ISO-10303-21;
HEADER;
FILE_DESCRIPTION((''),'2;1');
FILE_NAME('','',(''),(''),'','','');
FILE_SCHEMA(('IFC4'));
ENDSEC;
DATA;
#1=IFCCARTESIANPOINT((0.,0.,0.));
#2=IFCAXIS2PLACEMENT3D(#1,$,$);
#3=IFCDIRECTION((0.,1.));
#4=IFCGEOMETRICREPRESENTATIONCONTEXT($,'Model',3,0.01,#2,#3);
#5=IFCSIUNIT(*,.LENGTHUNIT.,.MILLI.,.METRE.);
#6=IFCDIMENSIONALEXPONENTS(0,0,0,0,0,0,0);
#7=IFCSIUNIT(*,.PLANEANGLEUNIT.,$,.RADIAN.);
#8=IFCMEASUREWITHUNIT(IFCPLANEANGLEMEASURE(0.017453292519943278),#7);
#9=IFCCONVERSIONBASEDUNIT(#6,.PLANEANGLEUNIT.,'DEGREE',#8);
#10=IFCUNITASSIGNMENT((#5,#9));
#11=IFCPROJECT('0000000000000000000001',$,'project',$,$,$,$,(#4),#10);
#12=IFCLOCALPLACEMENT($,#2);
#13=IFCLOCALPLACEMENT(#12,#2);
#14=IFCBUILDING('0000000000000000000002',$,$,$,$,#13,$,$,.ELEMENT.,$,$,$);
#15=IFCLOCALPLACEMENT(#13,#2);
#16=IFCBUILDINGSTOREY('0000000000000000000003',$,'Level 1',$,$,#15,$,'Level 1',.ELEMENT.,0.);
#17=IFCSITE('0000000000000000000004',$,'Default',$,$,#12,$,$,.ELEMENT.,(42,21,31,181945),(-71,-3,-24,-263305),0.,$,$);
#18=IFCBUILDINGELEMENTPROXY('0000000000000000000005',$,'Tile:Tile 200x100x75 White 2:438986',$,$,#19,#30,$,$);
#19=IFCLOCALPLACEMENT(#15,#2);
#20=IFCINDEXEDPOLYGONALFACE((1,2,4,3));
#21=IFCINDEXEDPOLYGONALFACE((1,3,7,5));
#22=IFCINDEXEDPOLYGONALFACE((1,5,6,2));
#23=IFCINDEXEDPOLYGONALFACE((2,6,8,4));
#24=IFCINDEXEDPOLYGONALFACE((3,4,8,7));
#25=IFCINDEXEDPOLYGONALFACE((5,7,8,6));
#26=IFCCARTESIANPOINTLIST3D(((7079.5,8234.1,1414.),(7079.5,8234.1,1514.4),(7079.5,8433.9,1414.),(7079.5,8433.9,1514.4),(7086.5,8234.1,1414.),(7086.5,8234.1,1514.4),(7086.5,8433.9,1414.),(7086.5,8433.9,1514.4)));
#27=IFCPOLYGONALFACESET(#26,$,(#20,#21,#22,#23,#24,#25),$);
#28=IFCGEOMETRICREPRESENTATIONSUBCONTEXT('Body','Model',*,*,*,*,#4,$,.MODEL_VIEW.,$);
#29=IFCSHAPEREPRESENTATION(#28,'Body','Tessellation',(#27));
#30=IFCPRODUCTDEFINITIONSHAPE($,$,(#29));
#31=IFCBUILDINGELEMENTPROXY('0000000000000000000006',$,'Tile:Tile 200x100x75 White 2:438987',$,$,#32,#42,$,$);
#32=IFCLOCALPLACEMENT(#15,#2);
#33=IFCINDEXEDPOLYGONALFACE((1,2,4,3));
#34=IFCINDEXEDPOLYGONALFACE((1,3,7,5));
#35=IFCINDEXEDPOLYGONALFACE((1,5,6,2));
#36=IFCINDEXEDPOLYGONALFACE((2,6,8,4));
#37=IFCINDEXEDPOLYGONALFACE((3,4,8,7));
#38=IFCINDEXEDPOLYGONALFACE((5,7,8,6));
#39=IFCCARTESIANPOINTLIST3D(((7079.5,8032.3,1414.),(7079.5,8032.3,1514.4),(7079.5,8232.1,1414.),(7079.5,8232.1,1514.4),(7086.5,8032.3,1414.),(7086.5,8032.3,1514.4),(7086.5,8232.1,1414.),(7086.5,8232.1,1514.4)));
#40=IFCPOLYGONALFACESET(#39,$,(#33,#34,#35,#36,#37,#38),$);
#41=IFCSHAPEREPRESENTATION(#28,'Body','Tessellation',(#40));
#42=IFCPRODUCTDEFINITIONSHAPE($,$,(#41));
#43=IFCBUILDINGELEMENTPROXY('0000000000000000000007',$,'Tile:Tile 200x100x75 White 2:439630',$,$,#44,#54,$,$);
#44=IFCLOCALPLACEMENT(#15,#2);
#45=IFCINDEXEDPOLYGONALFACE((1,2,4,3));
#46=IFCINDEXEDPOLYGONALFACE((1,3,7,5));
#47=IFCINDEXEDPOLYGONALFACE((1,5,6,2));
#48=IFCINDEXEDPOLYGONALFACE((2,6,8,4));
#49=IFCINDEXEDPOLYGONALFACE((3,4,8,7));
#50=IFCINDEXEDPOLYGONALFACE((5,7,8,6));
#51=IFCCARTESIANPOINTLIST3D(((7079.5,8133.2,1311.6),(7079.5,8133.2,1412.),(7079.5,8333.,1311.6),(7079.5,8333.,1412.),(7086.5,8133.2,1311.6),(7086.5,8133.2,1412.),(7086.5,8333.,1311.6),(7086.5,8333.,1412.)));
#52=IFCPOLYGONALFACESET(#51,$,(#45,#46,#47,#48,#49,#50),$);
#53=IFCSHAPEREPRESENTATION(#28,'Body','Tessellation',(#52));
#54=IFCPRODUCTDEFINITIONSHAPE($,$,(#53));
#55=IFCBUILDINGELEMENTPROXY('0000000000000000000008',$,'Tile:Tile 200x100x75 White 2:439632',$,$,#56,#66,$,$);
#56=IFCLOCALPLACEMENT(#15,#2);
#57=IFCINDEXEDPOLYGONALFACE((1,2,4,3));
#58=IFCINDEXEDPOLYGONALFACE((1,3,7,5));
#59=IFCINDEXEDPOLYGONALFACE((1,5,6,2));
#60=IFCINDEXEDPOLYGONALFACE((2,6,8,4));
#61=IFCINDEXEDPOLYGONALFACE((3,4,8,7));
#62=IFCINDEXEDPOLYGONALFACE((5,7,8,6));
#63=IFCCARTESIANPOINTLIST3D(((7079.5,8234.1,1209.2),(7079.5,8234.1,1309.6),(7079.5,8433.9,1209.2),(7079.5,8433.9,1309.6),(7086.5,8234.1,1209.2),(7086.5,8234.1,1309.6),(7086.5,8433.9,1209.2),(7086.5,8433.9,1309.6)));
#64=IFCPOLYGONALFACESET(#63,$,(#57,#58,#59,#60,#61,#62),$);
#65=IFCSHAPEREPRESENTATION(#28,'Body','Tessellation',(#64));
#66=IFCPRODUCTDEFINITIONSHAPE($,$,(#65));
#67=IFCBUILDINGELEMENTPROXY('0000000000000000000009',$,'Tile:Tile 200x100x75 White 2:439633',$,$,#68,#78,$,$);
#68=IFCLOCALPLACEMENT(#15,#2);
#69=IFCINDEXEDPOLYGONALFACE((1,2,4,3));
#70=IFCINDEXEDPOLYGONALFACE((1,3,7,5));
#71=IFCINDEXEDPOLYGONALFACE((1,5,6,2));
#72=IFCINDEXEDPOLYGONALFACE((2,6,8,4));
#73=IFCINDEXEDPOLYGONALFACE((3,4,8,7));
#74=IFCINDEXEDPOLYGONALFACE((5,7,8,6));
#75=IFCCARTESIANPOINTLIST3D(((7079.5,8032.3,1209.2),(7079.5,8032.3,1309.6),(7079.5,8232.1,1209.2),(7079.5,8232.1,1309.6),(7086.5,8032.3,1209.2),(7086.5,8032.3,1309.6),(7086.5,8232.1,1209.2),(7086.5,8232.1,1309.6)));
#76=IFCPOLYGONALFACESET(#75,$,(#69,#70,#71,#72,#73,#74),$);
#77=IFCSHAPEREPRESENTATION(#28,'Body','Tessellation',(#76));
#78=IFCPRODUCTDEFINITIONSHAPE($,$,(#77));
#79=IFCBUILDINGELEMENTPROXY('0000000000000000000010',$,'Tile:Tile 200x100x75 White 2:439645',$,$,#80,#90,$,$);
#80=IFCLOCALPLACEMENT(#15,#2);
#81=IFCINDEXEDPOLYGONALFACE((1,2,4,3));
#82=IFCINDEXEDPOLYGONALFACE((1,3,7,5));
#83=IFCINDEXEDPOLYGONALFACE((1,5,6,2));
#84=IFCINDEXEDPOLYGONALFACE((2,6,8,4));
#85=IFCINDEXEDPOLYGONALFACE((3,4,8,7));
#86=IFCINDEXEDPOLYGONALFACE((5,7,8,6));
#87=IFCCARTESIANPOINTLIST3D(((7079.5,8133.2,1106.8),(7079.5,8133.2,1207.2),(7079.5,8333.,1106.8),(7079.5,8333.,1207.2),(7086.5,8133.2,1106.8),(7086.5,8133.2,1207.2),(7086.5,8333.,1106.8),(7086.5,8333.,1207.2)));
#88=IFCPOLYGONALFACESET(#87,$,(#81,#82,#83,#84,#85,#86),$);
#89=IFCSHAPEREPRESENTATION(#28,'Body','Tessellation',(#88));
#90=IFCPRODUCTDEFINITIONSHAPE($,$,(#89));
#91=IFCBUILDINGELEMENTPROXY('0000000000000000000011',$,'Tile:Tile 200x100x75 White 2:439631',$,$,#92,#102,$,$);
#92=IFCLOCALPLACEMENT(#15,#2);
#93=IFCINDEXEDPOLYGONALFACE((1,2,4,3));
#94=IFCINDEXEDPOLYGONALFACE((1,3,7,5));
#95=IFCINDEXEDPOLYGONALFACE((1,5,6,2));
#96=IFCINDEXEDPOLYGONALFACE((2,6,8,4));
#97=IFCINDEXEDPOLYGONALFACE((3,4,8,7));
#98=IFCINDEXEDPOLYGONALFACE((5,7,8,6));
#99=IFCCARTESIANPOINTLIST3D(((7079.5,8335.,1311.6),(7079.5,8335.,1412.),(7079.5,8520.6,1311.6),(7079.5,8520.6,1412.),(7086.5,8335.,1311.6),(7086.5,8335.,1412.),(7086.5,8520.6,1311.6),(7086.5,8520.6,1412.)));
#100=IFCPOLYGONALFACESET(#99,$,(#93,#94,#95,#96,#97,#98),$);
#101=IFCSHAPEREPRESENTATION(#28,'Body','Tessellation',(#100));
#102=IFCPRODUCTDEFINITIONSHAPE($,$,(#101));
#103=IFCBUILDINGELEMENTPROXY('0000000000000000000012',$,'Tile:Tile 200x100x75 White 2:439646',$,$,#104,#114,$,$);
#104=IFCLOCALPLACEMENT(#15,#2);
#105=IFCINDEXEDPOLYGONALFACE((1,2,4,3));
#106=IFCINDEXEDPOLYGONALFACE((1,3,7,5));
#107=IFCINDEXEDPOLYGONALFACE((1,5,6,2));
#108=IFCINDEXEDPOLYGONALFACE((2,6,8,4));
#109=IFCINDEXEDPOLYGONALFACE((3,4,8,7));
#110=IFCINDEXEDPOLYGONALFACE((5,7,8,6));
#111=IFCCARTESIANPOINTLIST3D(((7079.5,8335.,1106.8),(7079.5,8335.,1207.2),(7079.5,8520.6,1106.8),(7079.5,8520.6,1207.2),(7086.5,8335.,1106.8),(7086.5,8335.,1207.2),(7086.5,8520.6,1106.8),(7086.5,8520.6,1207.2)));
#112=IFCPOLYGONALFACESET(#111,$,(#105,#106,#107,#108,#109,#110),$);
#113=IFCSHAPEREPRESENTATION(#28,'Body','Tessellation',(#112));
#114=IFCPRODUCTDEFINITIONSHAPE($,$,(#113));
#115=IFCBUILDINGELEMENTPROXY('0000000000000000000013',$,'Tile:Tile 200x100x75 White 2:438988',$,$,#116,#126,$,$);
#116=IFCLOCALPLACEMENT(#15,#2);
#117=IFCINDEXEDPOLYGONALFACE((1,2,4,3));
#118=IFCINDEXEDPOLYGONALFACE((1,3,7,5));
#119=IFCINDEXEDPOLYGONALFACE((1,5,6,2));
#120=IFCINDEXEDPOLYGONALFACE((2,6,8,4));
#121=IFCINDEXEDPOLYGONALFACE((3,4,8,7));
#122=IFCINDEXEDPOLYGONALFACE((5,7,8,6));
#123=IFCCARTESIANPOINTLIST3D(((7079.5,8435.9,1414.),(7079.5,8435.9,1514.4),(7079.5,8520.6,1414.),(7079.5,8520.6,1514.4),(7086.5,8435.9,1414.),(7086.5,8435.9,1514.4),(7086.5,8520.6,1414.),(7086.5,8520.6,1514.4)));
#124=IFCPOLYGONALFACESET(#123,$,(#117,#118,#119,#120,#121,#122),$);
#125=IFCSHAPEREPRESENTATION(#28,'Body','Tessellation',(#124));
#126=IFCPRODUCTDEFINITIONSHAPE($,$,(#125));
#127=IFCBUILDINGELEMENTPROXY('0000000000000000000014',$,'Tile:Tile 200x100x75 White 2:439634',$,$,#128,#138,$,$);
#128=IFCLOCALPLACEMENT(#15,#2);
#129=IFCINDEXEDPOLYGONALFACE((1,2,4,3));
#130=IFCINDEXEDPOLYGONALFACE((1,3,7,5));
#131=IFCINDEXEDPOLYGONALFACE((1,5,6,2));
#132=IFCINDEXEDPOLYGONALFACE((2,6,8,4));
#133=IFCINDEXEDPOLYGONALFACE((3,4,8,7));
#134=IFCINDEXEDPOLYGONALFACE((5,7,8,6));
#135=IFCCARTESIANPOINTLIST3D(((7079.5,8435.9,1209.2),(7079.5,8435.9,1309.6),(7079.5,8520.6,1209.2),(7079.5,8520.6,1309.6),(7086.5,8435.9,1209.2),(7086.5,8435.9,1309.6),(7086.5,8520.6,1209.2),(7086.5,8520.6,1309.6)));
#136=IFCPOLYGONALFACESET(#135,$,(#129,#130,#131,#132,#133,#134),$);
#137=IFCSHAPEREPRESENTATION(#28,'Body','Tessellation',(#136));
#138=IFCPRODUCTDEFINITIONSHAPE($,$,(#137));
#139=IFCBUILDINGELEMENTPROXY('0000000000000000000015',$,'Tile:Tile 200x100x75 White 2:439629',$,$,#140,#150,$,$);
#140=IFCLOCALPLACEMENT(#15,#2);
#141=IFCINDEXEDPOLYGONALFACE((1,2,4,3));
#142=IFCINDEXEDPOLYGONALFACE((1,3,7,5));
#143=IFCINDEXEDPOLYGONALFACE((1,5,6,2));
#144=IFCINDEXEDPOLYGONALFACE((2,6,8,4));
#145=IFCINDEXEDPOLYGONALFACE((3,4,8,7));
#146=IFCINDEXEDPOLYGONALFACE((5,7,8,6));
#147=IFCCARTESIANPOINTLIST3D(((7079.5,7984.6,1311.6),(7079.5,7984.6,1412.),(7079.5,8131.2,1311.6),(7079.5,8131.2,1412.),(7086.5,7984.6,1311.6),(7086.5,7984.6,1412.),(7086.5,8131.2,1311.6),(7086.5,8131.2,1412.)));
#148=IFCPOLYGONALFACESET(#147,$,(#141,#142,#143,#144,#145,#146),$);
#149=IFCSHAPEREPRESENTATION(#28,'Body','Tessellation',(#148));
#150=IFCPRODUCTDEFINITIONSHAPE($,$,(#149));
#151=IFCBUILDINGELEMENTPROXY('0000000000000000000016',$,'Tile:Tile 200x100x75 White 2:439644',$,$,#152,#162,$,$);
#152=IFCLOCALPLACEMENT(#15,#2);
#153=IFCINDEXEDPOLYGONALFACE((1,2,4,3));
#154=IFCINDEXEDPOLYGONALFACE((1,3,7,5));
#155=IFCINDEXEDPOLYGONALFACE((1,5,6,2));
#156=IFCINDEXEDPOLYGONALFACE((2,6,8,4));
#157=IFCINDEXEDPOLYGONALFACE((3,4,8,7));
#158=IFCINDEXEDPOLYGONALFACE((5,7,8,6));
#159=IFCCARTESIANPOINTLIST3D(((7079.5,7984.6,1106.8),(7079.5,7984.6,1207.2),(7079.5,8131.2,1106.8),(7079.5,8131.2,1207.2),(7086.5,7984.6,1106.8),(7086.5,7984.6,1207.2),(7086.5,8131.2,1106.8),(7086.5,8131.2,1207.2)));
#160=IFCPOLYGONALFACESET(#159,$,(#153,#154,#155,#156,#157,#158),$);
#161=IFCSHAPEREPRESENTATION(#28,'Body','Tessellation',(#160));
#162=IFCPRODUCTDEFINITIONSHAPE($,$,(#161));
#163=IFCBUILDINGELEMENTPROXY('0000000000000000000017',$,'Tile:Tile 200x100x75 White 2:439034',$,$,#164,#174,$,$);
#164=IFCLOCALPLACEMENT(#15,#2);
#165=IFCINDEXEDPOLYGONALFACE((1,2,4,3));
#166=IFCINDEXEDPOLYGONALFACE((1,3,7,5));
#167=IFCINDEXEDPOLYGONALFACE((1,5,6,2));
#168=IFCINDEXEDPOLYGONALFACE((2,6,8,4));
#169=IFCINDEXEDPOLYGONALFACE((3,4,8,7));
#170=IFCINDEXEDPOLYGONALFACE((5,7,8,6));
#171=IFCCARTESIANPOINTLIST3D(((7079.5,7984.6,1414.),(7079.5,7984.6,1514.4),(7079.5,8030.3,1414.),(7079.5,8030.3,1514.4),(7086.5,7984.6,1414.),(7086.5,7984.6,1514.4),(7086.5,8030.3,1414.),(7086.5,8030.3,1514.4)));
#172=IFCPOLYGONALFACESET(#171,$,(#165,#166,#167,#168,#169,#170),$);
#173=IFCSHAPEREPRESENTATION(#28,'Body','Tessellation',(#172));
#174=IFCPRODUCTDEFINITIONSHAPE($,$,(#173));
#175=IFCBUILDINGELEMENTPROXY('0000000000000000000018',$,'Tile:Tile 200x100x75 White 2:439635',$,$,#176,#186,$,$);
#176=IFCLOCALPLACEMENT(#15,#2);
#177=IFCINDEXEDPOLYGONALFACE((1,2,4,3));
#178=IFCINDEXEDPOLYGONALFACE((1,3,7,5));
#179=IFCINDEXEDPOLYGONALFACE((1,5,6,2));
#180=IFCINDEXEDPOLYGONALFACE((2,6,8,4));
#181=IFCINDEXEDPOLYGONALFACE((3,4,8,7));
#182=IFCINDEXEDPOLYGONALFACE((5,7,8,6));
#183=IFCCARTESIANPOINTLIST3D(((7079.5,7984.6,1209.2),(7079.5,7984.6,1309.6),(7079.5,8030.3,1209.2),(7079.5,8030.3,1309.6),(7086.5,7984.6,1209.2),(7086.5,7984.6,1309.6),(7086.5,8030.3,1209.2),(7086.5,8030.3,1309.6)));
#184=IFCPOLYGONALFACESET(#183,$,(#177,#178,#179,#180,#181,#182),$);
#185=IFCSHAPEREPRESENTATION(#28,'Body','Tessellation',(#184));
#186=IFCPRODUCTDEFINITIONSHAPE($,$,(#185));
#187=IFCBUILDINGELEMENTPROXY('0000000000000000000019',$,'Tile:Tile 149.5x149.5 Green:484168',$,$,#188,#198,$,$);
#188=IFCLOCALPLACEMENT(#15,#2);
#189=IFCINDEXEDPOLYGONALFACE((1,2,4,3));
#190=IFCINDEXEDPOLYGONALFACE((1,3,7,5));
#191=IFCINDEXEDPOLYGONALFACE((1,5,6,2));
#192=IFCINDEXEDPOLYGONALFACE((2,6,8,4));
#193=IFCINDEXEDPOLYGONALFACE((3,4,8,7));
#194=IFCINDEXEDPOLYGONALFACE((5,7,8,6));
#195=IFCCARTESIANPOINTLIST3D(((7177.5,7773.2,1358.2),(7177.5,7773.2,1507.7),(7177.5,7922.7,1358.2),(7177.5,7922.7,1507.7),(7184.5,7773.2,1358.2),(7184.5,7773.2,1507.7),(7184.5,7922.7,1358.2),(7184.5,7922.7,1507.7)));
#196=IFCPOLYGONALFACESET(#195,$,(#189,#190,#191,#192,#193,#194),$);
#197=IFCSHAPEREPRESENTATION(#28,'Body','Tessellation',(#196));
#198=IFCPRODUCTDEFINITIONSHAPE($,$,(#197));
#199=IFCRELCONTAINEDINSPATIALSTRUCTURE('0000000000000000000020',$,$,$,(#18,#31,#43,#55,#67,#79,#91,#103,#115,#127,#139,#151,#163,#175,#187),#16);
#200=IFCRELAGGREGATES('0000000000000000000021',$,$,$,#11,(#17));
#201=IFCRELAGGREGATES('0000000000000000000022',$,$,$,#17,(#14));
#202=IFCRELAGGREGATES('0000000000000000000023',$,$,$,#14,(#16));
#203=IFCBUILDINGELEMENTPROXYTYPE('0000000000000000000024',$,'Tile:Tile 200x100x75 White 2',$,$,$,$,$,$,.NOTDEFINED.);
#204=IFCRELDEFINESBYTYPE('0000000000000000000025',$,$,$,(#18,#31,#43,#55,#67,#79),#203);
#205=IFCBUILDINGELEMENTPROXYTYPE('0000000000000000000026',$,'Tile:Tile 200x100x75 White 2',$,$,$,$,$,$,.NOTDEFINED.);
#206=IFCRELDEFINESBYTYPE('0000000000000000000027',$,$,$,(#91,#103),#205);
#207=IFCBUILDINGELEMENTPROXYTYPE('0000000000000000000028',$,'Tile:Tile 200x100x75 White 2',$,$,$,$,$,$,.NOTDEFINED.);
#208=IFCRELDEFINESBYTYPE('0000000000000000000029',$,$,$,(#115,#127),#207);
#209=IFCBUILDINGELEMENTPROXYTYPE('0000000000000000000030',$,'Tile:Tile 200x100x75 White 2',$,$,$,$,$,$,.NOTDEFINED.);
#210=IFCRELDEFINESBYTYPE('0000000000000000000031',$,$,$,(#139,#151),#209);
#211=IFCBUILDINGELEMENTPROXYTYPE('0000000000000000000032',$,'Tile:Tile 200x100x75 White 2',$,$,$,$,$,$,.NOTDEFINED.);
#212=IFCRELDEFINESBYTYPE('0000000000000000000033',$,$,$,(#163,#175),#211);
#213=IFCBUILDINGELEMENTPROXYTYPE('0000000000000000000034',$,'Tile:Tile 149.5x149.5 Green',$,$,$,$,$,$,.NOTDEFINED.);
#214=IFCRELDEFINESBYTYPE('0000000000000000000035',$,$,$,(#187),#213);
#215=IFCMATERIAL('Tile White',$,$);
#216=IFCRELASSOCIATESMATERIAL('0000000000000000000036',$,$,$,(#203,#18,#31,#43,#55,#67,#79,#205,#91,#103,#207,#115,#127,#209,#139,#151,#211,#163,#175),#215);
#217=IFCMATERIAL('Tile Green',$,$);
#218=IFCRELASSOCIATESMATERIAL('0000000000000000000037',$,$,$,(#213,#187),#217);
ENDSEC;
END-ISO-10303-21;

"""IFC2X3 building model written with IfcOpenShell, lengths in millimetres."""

from ifc_helpers import new_model, entity, si_unit, converted_unit, direction, frame, frame_2d, origin, origin_2d_with_axis, place, context, subcontext, project, spatial, rectangle, extrude, source, transform, mapped, material, type_object, type_shapes, element, save


model = new_model("IFC2X3")

# Units and contexts
model_context = context("Model", 3, precision=0.01, world=origin(), true_north=direction((0.0, 1.0)))
body_context = subcontext(model_context, "Body", "Model", "MODEL_VIEW")
ifc_project = project(units=[si_unit("LENGTHUNIT", "METRE", prefix="MILLI"), converted_unit("PLANEANGLEUNIT", "DEGREE", entity("IfcPlaneAngleMeasure", 0.017453292519943278), si_unit("PLANEANGLEUNIT", "RADIAN"), dimensions=[0, 0, 0, 0, 0, 0, 0])], contexts=[model_context])

# Site, building, storey
site_placement = place(None, origin())
site = spatial("IfcSite", under=ifc_project, at=site_placement, Name="Default", CompositionType="ELEMENT", RefLatitude=(42, 21, 31, 181945), RefLongitude=(-71, -3, -24, -263305), RefElevation=0.0)
building_placement = place(site_placement, origin())
building = spatial("IfcBuilding", under=site, at=building_placement, CompositionType="ELEMENT")
storey_placement = place(building_placement, origin())
storey = spatial("IfcBuildingStorey", under=building, at=storey_placement, Name="Level 1", LongName="Level 1", CompositionType="ELEMENT", Elevation=0.0)

# Building element proxies
ifc_material_1 = material(Name="Tile White")
building_element_proxy_type_1 = type_object("IfcBuildingElementProxyType", Name="Tile:Tile 200x100x75 White 2", PredefinedType="NOTDEFINED", material=ifc_material_1)
shared_shape_1 = source(origin(), body_context, "Body", "SweptSolid", [
    extrude(rectangle(XDim=199.8, YDim=100.4, at=frame_2d((0.0, 0.0), x_axis=(1.0, 0.0))), frame((-50.2, -99.9, 0.0), z_axis=(0.0, 0.0, 1.0), x_axis=(0.0, -1.0, 0.0)), (0.0, 0.0, 1.0), 7.0),
])
type_shapes(building_element_proxy_type_1, [shared_shape_1])
for number, where, z_axis, x_axis, name in (
    (1, (7086.5, 8433.9, 1514.4), (-1.0, 0.0, 0.0), (0.0, 0.0, 1.0), "Tile:Tile 200x100x75 White 2:438986"),
    (2, (7086.5, 8232.1, 1514.4), (-1.0, 0.0, 0.0), (0.0, 0.0, 1.0), "Tile:Tile 200x100x75 White 2:438987"),
    (3, (7086.5, 8333.0, 1412.0), (-1.0, 0.0, 0.0), (0.0, 0.0, 1.0), "Tile:Tile 200x100x75 White 2:439630"),
    (4, (7086.5, 8433.9, 1309.6), (-1.0, 0.0, 0.0), (0.0, 0.0, 1.0), "Tile:Tile 200x100x75 White 2:439632"),
    (5, (7086.5, 8232.1, 1309.6), (-1.0, 0.0, 0.0), (0.0, 0.0, 1.0), "Tile:Tile 200x100x75 White 2:439633"),
    (6, (7086.5, 8333.0, 1207.2), (-1.0, 0.0, 0.0), (0.0, 0.0, 1.0), "Tile:Tile 200x100x75 White 2:439645"),
):
    element("IfcBuildingElementProxy", number, at=place(storey_placement, frame(where, z_axis=z_axis, x_axis=x_axis)), inside=storey, type_object=building_element_proxy_type_1, material=ifc_material_1, Name=name, context=body_context, shape_type="MappedRepresentation", body=[
        mapped(shared_shape_1, transform((0.0, 0.0, 0.0), scale=1.0)),
    ])
building_element_proxy_type_2 = type_object("IfcBuildingElementProxyType", Name="Tile:Tile 200x100x75 White 2", PredefinedType="NOTDEFINED", material=ifc_material_1)
shared_shape_2 = source(origin(), body_context, "Body", "SweptSolid", [
    extrude(rectangle(XDim=185.6, YDim=100.4, at=frame_2d((0.0, 0.0), x_axis=(1.0, 0.0))), frame((-50.2, -92.8, 0.0), z_axis=(0.0, 0.0, 1.0), x_axis=(0.0, -1.0, 0.0)), (0.0, 0.0, 1.0), 7.0),
])
type_shapes(building_element_proxy_type_2, [shared_shape_2])
for number, where, z_axis, x_axis, name in (
    (7, (7086.5, 8520.6, 1412.0), (-1.0, 0.0, 0.0), (0.0, 0.0, 1.0), "Tile:Tile 200x100x75 White 2:439631"),
    (8, (7086.5, 8520.6, 1207.2), (-1.0, 0.0, 0.0), (0.0, 0.0, 1.0), "Tile:Tile 200x100x75 White 2:439646"),
):
    element("IfcBuildingElementProxy", number, at=place(storey_placement, frame(where, z_axis=z_axis, x_axis=x_axis)), inside=storey, type_object=building_element_proxy_type_2, material=ifc_material_1, Name=name, context=body_context, shape_type="MappedRepresentation", body=[
        mapped(shared_shape_2, transform((0.0, 0.0, 0.0), scale=1.0)),
    ])
building_element_proxy_type_3 = type_object("IfcBuildingElementProxyType", Name="Tile:Tile 200x100x75 White 2", PredefinedType="NOTDEFINED", material=ifc_material_1)
shared_shape_3 = source(origin(), body_context, "Body", "SweptSolid", [
    extrude(rectangle(XDim=84.7, YDim=100.4, at=frame_2d((0.0, 0.0), x_axis=(1.0, 0.0))), frame((-50.2, -42.4, 0.0), z_axis=(0.0, 0.0, 1.0), x_axis=(0.0, -1.0, 0.0)), (0.0, 0.0, 1.0), 7.0),
])
type_shapes(building_element_proxy_type_3, [shared_shape_3])
for number, where, z_axis, x_axis, name in (
    (9, (7086.5, 8520.6, 1514.4), (-1.0, 0.0, 0.0), (0.0, 0.0, 1.0), "Tile:Tile 200x100x75 White 2:438988"),
    (10, (7086.5, 8520.6, 1309.6), (-1.0, 0.0, 0.0), (0.0, 0.0, 1.0), "Tile:Tile 200x100x75 White 2:439634"),
):
    element("IfcBuildingElementProxy", number, at=place(storey_placement, frame(where, z_axis=z_axis, x_axis=x_axis)), inside=storey, type_object=building_element_proxy_type_3, material=ifc_material_1, Name=name, context=body_context, shape_type="MappedRepresentation", body=[
        mapped(shared_shape_3, transform((0.0, 0.0, 0.0), scale=1.0)),
    ])
building_element_proxy_type_4 = type_object("IfcBuildingElementProxyType", Name="Tile:Tile 200x100x75 White 2", PredefinedType="NOTDEFINED", material=ifc_material_1)
shared_shape_4 = source(origin(), body_context, "Body", "SweptSolid", [
    extrude(rectangle(XDim=146.6, YDim=100.4, at=origin_2d_with_axis()), frame((-50.2, -73.3, 0.0), z_axis=(0.0, 0.0, 1.0), x_axis=(0.0, -1.0, 0.0)), (0.0, 0.0, 1.0), 7.0),
])
type_shapes(building_element_proxy_type_4, [shared_shape_4])
for number, where, z_axis, x_axis, name in (
    (11, (7086.5, 8131.2, 1412.0), (-1.0, 0.0, 0.0), (0.0, 0.0, 1.0), "Tile:Tile 200x100x75 White 2:439629"),
    (12, (7086.5, 8131.2, 1207.2), (-1.0, 0.0, 0.0), (0.0, 0.0, 1.0), "Tile:Tile 200x100x75 White 2:439644"),
):
    element("IfcBuildingElementProxy", number, at=place(storey_placement, frame(where, z_axis=z_axis, x_axis=x_axis)), inside=storey, type_object=building_element_proxy_type_4, material=ifc_material_1, Name=name, context=body_context, shape_type="MappedRepresentation", body=[
        mapped(shared_shape_4, transform((0.0, 0.0, 0.0), scale=1.0)),
    ])
building_element_proxy_type_5 = type_object("IfcBuildingElementProxyType", Name="Tile:Tile 200x100x75 White 2", PredefinedType="NOTDEFINED", material=ifc_material_1)
shared_shape_5 = source(origin(), body_context, "Body", "SweptSolid", [
    extrude(rectangle(XDim=45.7, YDim=100.4, at=frame_2d((0.0, 0.0), x_axis=(1.0, 0.0))), frame((-50.2, -22.9, 0.0), z_axis=(0.0, 0.0, 1.0), x_axis=(0.0, -1.0, 0.0)), (0.0, 0.0, 1.0), 7.0),
])
type_shapes(building_element_proxy_type_5, [shared_shape_5])
for number, where, z_axis, x_axis, name in (
    (13, (7086.5, 8030.3, 1514.4), (-1.0, 0.0, 0.0), (0.0, 0.0, 1.0), "Tile:Tile 200x100x75 White 2:439034"),
    (14, (7086.5, 8030.3, 1309.6), (-1.0, 0.0, 0.0), (0.0, 0.0, 1.0), "Tile:Tile 200x100x75 White 2:439635"),
):
    element("IfcBuildingElementProxy", number, at=place(storey_placement, frame(where, z_axis=z_axis, x_axis=x_axis)), inside=storey, type_object=building_element_proxy_type_5, material=ifc_material_1, Name=name, context=body_context, shape_type="MappedRepresentation", body=[
        mapped(shared_shape_5, transform((0.0, 0.0, 0.0), scale=1.0)),
    ])
ifc_material_2 = material(Name="Tile Green")
building_element_proxy_type_6 = type_object("IfcBuildingElementProxyType", Name="Tile:Tile 149.5x149.5 Green", PredefinedType="NOTDEFINED", material=ifc_material_2)
shared_shape_6 = source(origin(), body_context, "Body", "SweptSolid", [
    extrude(rectangle(XDim=149.5, YDim=149.5, at=origin_2d_with_axis()), frame((-74.7, -74.8, 0.0), z_axis=(0.0, 0.0, 1.0), x_axis=(0.0, -1.0, 0.0)), (0.0, 0.0, 1.0), 7.0),
])
type_shapes(building_element_proxy_type_6, [shared_shape_6])
for number, where, z_axis, x_axis, name in (
    (15, (7184.5, 7922.7, 1507.7), (-1.0, 0.0, 0.0), (0.0, 0.0, 1.0), "Tile:Tile 149.5x149.5 Green:484168"),
):
    element("IfcBuildingElementProxy", number, at=place(storey_placement, frame(where, z_axis=z_axis, x_axis=x_axis)), inside=storey, type_object=building_element_proxy_type_6, material=ifc_material_2, Name=name, context=body_context, shape_type="MappedRepresentation", body=[
        mapped(shared_shape_6, transform((0.0, 0.0, 0.0), scale=1.0)),
    ])

save(model, "model.ifc")
